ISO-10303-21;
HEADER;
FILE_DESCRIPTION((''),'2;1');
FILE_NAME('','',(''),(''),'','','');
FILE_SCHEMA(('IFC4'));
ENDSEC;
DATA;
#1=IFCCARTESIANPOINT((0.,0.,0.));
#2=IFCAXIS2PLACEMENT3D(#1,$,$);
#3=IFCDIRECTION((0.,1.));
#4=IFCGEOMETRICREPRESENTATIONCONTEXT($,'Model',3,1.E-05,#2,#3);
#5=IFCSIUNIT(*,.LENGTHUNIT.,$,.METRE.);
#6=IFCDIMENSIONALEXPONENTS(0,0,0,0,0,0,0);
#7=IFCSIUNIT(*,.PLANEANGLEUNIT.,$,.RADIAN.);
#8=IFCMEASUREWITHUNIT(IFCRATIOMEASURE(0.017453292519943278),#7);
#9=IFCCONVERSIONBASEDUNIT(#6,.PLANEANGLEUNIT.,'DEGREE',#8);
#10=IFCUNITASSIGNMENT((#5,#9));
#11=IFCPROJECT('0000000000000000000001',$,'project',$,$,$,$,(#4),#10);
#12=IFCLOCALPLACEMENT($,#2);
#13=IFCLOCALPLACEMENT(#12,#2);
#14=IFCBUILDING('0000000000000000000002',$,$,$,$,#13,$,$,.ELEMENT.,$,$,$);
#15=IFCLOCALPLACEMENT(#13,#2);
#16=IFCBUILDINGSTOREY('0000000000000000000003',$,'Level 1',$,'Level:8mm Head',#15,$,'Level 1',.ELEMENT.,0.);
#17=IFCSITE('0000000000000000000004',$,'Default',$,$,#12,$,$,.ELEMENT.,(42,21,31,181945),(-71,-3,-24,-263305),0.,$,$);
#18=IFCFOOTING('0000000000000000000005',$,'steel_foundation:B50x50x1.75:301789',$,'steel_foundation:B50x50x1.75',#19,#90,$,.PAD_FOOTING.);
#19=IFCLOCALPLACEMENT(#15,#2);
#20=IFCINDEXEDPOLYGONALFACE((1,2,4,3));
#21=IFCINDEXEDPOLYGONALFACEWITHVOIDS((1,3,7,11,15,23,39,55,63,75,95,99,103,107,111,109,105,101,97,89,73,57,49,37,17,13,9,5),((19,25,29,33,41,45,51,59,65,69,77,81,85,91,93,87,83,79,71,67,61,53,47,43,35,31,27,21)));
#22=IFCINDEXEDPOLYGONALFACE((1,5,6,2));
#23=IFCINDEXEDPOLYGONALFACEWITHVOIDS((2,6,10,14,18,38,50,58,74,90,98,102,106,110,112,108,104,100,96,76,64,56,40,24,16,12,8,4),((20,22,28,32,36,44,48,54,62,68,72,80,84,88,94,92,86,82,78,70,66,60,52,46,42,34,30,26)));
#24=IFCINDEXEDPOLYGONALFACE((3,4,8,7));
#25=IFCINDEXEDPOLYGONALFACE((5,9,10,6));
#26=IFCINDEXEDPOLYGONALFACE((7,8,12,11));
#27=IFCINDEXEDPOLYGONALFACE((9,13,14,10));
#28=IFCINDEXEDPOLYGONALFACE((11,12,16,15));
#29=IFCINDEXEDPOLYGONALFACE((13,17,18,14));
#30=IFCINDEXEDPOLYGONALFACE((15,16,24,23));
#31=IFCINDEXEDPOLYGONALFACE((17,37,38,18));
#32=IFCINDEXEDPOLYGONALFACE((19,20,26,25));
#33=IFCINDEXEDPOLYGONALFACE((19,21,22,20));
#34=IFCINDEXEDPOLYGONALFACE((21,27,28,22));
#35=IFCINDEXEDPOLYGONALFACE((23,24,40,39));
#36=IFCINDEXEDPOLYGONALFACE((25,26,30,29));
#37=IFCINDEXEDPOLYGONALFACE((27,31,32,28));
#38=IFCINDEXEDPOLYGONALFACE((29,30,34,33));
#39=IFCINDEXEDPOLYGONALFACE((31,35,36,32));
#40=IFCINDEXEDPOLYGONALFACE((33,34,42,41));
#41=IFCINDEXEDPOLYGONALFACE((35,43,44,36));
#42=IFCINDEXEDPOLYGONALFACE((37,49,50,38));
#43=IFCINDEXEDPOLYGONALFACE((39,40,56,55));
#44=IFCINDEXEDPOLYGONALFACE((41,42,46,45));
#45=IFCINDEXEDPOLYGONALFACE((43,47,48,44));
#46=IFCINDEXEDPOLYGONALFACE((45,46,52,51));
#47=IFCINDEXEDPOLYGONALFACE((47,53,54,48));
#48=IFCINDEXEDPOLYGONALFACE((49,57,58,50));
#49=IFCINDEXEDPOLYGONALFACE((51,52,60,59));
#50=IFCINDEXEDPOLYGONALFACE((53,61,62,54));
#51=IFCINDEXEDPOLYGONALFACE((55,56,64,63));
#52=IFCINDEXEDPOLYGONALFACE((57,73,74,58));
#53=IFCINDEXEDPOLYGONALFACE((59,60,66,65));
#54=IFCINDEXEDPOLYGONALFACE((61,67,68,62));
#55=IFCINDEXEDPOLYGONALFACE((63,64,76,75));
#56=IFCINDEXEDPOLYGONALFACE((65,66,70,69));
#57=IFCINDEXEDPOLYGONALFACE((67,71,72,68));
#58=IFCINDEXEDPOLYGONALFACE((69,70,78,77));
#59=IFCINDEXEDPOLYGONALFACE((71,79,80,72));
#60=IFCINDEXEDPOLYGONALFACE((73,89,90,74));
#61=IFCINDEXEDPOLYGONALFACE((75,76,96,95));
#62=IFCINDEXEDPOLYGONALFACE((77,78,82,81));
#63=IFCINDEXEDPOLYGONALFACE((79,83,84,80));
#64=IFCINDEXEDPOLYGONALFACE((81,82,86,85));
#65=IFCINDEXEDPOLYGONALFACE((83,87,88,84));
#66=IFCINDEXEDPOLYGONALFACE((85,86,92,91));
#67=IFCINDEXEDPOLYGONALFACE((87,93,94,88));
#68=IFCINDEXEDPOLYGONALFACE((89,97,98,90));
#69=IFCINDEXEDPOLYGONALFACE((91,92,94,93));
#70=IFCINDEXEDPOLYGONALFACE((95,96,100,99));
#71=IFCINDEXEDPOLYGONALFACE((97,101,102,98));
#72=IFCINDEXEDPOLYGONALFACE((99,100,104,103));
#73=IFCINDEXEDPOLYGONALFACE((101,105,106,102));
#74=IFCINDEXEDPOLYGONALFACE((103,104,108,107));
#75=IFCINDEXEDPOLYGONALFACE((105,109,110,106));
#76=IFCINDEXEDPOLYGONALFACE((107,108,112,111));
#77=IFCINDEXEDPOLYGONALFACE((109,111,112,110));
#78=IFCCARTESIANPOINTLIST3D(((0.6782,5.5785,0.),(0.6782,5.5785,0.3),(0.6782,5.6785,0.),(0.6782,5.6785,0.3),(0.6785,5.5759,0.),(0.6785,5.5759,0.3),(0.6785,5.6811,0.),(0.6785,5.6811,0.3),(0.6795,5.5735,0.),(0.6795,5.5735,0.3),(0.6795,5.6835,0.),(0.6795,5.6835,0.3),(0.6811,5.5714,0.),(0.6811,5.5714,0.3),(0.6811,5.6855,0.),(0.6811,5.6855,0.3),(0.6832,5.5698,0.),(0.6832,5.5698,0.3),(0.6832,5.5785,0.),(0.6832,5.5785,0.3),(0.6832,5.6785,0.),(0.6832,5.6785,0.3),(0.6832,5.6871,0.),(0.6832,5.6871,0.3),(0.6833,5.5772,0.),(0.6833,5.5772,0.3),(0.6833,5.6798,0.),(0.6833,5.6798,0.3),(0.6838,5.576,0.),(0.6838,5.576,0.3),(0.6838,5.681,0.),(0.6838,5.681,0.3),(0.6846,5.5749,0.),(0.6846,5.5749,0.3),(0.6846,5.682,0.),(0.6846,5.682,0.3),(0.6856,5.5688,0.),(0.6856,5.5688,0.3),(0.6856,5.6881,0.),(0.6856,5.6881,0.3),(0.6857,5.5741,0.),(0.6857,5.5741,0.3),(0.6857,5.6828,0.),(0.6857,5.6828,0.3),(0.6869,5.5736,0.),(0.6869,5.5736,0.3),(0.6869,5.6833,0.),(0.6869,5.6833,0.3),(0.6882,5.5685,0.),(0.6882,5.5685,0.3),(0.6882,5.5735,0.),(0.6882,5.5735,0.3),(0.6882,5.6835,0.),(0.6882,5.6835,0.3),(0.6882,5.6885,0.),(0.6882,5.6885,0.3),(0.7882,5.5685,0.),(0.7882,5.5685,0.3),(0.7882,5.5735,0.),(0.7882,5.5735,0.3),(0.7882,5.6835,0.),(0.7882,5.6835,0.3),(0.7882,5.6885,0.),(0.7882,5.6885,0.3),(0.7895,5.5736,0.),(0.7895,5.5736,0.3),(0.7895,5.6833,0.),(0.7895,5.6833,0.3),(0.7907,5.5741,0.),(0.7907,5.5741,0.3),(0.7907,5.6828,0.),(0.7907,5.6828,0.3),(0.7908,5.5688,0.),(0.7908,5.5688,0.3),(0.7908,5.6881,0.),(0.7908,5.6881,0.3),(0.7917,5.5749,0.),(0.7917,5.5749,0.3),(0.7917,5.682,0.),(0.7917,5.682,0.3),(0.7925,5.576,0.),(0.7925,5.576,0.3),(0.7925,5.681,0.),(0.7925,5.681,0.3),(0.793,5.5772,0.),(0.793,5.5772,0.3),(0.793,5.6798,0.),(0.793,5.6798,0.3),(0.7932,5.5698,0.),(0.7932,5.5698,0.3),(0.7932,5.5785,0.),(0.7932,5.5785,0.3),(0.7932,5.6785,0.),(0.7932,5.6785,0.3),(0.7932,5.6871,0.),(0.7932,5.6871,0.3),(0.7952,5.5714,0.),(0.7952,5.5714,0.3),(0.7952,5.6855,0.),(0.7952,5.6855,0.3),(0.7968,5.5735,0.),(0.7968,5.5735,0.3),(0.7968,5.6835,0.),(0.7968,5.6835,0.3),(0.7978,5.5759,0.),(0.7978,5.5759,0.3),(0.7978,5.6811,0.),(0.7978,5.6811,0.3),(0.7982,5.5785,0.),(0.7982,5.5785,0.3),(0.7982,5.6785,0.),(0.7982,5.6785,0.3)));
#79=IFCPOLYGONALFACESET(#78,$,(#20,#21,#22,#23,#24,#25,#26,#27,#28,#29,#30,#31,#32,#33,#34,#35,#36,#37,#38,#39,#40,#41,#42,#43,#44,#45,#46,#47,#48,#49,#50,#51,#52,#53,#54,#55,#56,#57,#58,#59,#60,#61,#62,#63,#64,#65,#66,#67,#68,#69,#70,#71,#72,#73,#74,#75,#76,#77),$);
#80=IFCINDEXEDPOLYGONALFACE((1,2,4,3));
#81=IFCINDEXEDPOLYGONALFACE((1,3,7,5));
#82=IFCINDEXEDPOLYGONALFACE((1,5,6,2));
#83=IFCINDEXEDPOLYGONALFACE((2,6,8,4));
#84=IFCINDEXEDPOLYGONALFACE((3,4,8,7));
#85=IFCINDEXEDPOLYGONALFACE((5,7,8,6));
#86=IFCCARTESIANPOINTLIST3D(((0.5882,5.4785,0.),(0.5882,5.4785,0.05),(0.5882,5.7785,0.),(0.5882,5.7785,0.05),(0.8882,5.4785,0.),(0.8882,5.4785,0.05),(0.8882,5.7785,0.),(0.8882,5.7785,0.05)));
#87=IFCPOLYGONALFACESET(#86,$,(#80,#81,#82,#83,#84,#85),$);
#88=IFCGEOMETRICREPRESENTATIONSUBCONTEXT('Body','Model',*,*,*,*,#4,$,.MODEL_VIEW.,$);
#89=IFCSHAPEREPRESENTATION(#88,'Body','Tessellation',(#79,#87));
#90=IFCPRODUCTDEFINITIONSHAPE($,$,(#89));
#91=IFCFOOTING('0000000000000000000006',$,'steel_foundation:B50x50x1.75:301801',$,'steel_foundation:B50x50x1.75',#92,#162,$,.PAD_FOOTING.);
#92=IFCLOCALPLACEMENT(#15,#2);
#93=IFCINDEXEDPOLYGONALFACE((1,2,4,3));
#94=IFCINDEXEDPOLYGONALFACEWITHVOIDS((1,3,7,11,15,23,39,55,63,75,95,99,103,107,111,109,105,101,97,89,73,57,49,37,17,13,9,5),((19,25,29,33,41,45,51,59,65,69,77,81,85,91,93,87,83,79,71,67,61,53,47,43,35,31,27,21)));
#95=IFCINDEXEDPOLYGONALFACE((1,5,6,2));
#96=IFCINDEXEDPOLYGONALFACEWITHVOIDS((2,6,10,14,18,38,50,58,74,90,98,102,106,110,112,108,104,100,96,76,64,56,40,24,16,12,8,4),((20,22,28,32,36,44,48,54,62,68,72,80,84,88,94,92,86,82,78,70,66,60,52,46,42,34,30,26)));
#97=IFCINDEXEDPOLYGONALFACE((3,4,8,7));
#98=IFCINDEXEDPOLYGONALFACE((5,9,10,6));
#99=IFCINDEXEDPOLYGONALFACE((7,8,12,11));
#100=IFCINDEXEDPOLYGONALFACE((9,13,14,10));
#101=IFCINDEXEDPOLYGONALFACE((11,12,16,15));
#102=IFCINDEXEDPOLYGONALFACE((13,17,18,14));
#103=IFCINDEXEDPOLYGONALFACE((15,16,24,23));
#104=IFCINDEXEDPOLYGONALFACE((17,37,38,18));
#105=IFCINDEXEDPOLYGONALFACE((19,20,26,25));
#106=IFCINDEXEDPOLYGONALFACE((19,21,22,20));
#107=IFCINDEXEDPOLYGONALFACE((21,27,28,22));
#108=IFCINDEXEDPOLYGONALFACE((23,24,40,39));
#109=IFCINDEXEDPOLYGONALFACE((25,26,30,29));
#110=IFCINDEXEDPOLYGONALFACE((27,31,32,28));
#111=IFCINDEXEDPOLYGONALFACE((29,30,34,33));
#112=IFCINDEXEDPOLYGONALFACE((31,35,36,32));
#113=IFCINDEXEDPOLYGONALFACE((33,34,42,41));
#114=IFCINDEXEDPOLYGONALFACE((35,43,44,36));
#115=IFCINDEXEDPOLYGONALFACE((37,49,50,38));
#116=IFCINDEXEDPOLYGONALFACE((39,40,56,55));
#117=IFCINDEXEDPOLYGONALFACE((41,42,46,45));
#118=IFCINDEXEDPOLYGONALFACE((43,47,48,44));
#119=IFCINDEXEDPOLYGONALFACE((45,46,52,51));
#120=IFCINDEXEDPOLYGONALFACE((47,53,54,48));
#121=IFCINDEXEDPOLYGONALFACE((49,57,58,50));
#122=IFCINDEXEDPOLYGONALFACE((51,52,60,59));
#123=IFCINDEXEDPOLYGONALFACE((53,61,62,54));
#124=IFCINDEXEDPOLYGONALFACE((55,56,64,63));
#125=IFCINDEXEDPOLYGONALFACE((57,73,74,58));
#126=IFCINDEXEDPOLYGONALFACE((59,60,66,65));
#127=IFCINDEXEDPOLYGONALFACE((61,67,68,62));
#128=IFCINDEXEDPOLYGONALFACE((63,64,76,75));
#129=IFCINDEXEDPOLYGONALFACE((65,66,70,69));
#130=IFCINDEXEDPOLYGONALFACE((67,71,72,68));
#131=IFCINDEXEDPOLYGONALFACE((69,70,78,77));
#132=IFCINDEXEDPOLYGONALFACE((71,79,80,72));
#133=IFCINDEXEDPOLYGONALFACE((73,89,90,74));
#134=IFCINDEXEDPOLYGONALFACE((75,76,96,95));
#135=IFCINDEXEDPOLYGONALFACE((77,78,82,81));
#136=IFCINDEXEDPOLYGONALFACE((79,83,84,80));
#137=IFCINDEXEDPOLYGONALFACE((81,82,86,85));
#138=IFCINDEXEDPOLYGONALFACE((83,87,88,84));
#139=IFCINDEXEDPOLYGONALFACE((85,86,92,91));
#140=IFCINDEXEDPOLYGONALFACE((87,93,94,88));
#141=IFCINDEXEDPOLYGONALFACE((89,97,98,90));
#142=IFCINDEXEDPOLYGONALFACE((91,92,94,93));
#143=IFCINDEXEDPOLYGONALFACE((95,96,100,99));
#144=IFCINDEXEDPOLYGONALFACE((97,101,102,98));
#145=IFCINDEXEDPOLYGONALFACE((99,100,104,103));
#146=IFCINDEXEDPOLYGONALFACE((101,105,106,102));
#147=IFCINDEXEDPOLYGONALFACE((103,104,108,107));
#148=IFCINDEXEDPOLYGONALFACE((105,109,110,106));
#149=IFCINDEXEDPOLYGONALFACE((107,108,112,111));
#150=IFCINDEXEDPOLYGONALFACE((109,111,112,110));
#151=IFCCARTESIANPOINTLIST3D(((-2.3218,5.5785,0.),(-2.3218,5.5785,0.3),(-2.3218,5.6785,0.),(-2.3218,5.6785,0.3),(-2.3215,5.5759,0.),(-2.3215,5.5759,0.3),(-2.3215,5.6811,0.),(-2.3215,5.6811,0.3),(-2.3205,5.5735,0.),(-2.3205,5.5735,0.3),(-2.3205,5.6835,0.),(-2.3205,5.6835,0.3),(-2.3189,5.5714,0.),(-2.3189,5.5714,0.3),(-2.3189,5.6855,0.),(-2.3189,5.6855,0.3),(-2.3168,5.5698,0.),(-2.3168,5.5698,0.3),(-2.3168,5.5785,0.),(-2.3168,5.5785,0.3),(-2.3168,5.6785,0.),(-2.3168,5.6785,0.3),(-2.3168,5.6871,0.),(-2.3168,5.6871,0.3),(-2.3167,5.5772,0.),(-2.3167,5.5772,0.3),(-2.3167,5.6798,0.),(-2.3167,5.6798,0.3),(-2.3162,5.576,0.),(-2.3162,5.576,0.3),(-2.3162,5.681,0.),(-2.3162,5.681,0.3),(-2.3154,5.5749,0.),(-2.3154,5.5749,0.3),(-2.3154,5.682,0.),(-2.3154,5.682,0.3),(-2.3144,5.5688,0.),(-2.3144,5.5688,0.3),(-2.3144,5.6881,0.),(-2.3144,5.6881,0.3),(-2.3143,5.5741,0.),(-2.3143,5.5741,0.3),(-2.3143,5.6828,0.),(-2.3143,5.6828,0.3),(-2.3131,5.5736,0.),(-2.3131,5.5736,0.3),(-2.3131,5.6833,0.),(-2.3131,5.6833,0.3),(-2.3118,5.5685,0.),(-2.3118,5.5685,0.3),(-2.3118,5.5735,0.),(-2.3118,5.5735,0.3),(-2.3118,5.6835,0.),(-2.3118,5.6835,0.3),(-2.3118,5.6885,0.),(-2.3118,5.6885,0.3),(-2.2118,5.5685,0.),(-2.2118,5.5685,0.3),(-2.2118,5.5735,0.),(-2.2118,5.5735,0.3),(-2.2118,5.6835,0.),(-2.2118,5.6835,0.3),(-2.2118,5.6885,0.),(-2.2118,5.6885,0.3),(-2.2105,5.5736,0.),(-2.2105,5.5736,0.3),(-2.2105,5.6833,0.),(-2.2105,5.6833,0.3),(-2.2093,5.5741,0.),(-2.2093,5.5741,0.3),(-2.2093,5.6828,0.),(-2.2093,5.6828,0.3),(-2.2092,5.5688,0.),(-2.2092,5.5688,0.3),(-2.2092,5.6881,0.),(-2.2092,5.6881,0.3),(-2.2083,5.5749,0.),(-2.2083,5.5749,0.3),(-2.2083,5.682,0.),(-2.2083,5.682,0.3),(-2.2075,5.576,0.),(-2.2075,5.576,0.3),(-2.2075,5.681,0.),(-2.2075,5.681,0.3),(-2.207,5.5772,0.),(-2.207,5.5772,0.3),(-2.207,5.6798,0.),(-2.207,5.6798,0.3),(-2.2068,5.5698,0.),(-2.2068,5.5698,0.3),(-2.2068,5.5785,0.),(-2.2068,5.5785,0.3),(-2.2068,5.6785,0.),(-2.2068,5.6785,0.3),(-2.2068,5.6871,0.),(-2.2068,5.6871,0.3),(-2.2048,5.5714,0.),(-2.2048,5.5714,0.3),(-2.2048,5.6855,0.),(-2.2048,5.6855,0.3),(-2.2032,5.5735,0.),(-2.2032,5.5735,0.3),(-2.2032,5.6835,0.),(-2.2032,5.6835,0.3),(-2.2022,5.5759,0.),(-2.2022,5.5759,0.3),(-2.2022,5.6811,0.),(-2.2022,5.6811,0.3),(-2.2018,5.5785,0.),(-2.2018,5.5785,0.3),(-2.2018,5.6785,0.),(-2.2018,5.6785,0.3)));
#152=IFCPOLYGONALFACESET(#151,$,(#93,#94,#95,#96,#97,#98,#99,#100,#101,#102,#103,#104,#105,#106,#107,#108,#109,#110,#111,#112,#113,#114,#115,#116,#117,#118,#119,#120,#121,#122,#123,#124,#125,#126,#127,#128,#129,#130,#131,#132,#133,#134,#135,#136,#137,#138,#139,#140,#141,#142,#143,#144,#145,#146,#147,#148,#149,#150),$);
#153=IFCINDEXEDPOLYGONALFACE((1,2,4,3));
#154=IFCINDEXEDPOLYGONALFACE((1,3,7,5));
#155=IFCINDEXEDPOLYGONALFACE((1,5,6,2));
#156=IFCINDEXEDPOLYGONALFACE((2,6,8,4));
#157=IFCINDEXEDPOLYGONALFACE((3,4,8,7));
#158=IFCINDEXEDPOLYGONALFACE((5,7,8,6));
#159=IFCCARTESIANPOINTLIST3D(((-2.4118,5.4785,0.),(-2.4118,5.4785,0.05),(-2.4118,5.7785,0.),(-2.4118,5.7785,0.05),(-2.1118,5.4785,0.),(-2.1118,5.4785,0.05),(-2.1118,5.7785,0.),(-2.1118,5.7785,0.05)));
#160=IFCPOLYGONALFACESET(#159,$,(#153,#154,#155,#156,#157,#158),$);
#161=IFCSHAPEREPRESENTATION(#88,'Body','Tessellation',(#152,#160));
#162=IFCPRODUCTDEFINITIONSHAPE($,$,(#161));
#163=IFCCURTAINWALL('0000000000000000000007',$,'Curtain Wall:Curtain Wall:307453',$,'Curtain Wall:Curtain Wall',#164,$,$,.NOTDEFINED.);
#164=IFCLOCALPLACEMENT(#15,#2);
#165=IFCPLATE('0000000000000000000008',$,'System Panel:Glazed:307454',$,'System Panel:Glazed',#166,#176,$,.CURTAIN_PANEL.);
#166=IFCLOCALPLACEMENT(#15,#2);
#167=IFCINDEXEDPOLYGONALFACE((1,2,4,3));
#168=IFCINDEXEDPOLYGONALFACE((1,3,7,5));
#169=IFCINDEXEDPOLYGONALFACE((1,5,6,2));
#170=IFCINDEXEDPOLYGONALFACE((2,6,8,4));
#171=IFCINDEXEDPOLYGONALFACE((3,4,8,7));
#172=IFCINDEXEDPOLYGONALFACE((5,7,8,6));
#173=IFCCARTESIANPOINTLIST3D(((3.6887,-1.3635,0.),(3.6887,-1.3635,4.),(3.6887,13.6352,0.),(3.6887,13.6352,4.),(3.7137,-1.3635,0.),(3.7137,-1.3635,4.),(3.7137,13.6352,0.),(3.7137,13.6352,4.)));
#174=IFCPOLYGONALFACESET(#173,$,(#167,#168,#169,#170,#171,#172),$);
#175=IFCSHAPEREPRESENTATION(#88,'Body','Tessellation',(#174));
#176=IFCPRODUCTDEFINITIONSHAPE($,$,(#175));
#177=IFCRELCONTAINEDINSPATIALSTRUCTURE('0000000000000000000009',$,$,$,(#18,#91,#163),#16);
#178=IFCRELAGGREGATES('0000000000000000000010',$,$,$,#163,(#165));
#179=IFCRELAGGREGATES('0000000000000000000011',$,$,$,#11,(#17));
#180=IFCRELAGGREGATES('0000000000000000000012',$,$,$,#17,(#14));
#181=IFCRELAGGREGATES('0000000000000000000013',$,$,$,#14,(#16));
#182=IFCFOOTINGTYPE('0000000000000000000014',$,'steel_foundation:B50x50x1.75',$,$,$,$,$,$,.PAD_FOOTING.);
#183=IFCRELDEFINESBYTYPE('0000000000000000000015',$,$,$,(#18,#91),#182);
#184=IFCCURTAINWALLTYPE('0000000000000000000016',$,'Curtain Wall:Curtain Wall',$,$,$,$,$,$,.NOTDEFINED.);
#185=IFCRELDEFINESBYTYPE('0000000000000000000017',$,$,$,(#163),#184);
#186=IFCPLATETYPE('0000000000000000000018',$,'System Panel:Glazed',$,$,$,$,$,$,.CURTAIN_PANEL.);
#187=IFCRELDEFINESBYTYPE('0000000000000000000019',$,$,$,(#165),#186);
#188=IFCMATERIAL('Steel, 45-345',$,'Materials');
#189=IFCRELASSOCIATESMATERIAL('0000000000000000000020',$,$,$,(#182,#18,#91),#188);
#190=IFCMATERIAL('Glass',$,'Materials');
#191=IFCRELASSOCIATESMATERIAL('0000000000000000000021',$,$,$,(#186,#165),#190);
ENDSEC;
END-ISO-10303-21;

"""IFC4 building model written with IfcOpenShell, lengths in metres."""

from ifc_helpers import new_model, entity, si_unit, converted_unit, direction, frame, frame_2d, origin, origin_2d_with_axis, place, context, subcontext, project, spatial, polyline, circle_curve, parameter, trimmed, segment, composite_curve, rectangle, outline, extrude, source, transform, mapped, material, type_object, type_shapes, element, aggregate, save


model = new_model("IFC4")

# Units and contexts
model_context = context("Model", 3, precision=1e-05, world=origin(), true_north=direction((0.0, 1.0)))
body_context = subcontext(model_context, "Body", "Model", "MODEL_VIEW")
ifc_project = project(units=[si_unit("LENGTHUNIT", "METRE"), converted_unit("PLANEANGLEUNIT", "DEGREE", entity("IfcRatioMeasure", 0.017453292519943278), si_unit("PLANEANGLEUNIT", "RADIAN"), dimensions=[0, 0, 0, 0, 0, 0, 0])], contexts=[model_context])

# Site, building, storey
site_placement = place(None, origin())
site = spatial("IfcSite", under=ifc_project, at=site_placement, Name="Default", CompositionType="ELEMENT", RefLatitude=(42, 21, 31, 181945), RefLongitude=(-71, -3, -24, -263305), RefElevation=0.0)
building_placement = place(site_placement, origin())
building = spatial("IfcBuilding", under=site, at=building_placement, CompositionType="ELEMENT")
storey_placement = place(building_placement, origin())
storey = spatial("IfcBuildingStorey", under=building, at=storey_placement, Name="Level 1", ObjectType="Level:8mm Head", LongName="Level 1", CompositionType="ELEMENT", Elevation=0.0)

# Footings
ifc_material_1 = material(Name="Steel, 45-345", Category="Materials")
footing_type = type_object("IfcFootingType", Name="steel_foundation:B50x50x1.75", PredefinedType="PAD_FOOTING", material=ifc_material_1)
shared_shape_1 = source(origin(), body_context, "Body", "SweptSolid", [
    extrude(outline(composite_curve([segment(polyline([(-0.05, -0.06), (0.05, -0.06)]), True, "CONTINUOUS"), segment(trimmed(circle_curve(frame_2d((0.05, -0.05), x_axis=(-1.0, 0.0)), 0.01), [parameter(90.0)], [parameter(180.0)], True, "PARAMETER"), True, "CONTINUOUS"), segment(polyline([(0.06, -0.05), (0.06, 0.05)]), True, "CONTINUOUS"), segment(trimmed(circle_curve(frame_2d((0.05, 0.05), x_axis=(-1.0, 0.0)), 0.01), [parameter(180.0)], [parameter(270.0)], True, "PARAMETER"), True, "CONTINUOUS"), segment(polyline([(0.05, 0.06), (-0.05, 0.06)]), True, "CONTINUOUS"), segment(trimmed(circle_curve(frame_2d((-0.05, 0.05), x_axis=(-1.0, 0.0)), 0.01), [parameter(270.0)], [parameter(360.0)], True, "PARAMETER"), True, "CONTINUOUS"), segment(polyline([(-0.06, 0.05), (-0.06, -0.05)]), True, "CONTINUOUS"), segment(trimmed(circle_curve(frame_2d((-0.05, -0.05), x_axis=(-1.0, 0.0)), 0.01), [parameter(360.0)], [parameter(90.0)], True, "PARAMETER"), True, "CONTINUOUS")], self_intersect=False), holes=[composite_curve([segment(trimmed(circle_curve(frame_2d((-0.05, -0.05), x_axis=(-1.0, 0.0)), 0.005), [parameter(0.0)], [parameter(90.0)], True, "PARAMETER"), False, "CONTINUOUS"), segment(polyline([(-0.055, -0.05), (-0.055, 0.05)]), True, "CONTINUOUS"), segment(trimmed(circle_curve(frame_2d((-0.05, 0.05), x_axis=(-1.0, 0.0)), 0.005), [parameter(270.0)], [parameter(360.0)], True, "PARAMETER"), False, "CONTINUOUS"), segment(polyline([(-0.05, 0.055), (0.05, 0.055)]), True, "CONTINUOUS"), segment(trimmed(circle_curve(frame_2d((0.05, 0.05), x_axis=(-1.0, 0.0)), 0.005), [parameter(180.0)], [parameter(270.0)], True, "PARAMETER"), False, "CONTINUOUS"), segment(polyline([(0.055, 0.05), (0.055, -0.05)]), True, "CONTINUOUS"), segment(trimmed(circle_curve(frame_2d((0.05, -0.05), x_axis=(-1.0, 0.0)), 0.005), [parameter(90.0)], [parameter(180.0)], True, "PARAMETER"), False, "CONTINUOUS"), segment(polyline([(0.05, -0.055), (-0.05, -0.055)]), True, "CONTINUOUS")], self_intersect=False)]), frame((0.0, 0.0, 0.0), z_axis=(0.0, 0.0, 1.0), x_axis=(-1.0, 0.0, 0.0)), (0.0, 0.0, 1.0), 0.3),
    extrude(rectangle(XDim=0.3, YDim=0.3, at=frame_2d((0.0, 0.0), x_axis=(1.0, 0.0))), frame((0.0, 0.0, 0.0), z_axis=(0.0, 0.0, 1.0), x_axis=(-1.0, 0.0, 0.0)), (0.0, 0.0, 1.0), 0.05),
])
type_shapes(footing_type, [shared_shape_1])
for number, where, name in (
    (1, (0.7382, 5.6285, 0.0), "steel_foundation:B50x50x1.75:301789"),
    (2, (-2.2618, 5.6285, 0.0), "steel_foundation:B50x50x1.75:301801"),
):
    element("IfcFooting", number, at=place(storey_placement, frame(where)), inside=storey, type_object=footing_type, material=ifc_material_1, Name=name, ObjectType="steel_foundation:B50x50x1.75", PredefinedType="PAD_FOOTING", context=body_context, shape_type="MappedRepresentation", body=[
        mapped(shared_shape_1, transform((0.0, 0.0, 0.0), scale=1.0)),
    ])

# Curtain wall, plate
curtain_wall_type = type_object("IfcCurtainWallType", Name="Curtain Wall:Curtain Wall", PredefinedType="NOTDEFINED")
curtain_wall_1_placement = place(storey_placement, origin())
curtain_wall_1 = element("IfcCurtainWall", 3, at=curtain_wall_1_placement, inside=storey, type_object=curtain_wall_type, Name="Curtain Wall:Curtain Wall:307453", ObjectType="Curtain Wall:Curtain Wall", PredefinedType="NOTDEFINED")
ifc_material_2 = material(Name="Glass", Category="Materials")
plate_type_1 = type_object("IfcPlateType", Name="System Panel:Glazed", PredefinedType="CURTAIN_PANEL", material=ifc_material_2)
shared_shape_2 = source(origin(), body_context, "Body", "SweptSolid", [
    extrude(rectangle(XDim=0.025, YDim=14.9987, at=origin_2d_with_axis()), frame((7.4993, 0.0125, 0.0), z_axis=(0.0, 0.0, 1.0), x_axis=(0.0, 1.0, 0.0)), (0.0, 0.0, 1.0), 4.0),
])
type_shapes(plate_type_1, [shared_shape_2])
plate_1_placement = place(curtain_wall_1_placement, frame((3.7137, -1.3635, 0.0), z_axis=(0.0, 0.0, 1.0), x_axis=(0.0, 1.0, 0.0)))
plate_1 = element("IfcPlate", 4, at=plate_1_placement, type_object=plate_type_1, material=ifc_material_2, Name="System Panel:Glazed:307454", ObjectType="System Panel:Glazed", PredefinedType="CURTAIN_PANEL", context=body_context, shape_type="MappedRepresentation", body=[
    mapped(shared_shape_2, transform((0.0, 0.0, 0.0), scale=1.0)),
])
aggregate(curtain_wall_1, [plate_1])

save(model, "model.ifc")
